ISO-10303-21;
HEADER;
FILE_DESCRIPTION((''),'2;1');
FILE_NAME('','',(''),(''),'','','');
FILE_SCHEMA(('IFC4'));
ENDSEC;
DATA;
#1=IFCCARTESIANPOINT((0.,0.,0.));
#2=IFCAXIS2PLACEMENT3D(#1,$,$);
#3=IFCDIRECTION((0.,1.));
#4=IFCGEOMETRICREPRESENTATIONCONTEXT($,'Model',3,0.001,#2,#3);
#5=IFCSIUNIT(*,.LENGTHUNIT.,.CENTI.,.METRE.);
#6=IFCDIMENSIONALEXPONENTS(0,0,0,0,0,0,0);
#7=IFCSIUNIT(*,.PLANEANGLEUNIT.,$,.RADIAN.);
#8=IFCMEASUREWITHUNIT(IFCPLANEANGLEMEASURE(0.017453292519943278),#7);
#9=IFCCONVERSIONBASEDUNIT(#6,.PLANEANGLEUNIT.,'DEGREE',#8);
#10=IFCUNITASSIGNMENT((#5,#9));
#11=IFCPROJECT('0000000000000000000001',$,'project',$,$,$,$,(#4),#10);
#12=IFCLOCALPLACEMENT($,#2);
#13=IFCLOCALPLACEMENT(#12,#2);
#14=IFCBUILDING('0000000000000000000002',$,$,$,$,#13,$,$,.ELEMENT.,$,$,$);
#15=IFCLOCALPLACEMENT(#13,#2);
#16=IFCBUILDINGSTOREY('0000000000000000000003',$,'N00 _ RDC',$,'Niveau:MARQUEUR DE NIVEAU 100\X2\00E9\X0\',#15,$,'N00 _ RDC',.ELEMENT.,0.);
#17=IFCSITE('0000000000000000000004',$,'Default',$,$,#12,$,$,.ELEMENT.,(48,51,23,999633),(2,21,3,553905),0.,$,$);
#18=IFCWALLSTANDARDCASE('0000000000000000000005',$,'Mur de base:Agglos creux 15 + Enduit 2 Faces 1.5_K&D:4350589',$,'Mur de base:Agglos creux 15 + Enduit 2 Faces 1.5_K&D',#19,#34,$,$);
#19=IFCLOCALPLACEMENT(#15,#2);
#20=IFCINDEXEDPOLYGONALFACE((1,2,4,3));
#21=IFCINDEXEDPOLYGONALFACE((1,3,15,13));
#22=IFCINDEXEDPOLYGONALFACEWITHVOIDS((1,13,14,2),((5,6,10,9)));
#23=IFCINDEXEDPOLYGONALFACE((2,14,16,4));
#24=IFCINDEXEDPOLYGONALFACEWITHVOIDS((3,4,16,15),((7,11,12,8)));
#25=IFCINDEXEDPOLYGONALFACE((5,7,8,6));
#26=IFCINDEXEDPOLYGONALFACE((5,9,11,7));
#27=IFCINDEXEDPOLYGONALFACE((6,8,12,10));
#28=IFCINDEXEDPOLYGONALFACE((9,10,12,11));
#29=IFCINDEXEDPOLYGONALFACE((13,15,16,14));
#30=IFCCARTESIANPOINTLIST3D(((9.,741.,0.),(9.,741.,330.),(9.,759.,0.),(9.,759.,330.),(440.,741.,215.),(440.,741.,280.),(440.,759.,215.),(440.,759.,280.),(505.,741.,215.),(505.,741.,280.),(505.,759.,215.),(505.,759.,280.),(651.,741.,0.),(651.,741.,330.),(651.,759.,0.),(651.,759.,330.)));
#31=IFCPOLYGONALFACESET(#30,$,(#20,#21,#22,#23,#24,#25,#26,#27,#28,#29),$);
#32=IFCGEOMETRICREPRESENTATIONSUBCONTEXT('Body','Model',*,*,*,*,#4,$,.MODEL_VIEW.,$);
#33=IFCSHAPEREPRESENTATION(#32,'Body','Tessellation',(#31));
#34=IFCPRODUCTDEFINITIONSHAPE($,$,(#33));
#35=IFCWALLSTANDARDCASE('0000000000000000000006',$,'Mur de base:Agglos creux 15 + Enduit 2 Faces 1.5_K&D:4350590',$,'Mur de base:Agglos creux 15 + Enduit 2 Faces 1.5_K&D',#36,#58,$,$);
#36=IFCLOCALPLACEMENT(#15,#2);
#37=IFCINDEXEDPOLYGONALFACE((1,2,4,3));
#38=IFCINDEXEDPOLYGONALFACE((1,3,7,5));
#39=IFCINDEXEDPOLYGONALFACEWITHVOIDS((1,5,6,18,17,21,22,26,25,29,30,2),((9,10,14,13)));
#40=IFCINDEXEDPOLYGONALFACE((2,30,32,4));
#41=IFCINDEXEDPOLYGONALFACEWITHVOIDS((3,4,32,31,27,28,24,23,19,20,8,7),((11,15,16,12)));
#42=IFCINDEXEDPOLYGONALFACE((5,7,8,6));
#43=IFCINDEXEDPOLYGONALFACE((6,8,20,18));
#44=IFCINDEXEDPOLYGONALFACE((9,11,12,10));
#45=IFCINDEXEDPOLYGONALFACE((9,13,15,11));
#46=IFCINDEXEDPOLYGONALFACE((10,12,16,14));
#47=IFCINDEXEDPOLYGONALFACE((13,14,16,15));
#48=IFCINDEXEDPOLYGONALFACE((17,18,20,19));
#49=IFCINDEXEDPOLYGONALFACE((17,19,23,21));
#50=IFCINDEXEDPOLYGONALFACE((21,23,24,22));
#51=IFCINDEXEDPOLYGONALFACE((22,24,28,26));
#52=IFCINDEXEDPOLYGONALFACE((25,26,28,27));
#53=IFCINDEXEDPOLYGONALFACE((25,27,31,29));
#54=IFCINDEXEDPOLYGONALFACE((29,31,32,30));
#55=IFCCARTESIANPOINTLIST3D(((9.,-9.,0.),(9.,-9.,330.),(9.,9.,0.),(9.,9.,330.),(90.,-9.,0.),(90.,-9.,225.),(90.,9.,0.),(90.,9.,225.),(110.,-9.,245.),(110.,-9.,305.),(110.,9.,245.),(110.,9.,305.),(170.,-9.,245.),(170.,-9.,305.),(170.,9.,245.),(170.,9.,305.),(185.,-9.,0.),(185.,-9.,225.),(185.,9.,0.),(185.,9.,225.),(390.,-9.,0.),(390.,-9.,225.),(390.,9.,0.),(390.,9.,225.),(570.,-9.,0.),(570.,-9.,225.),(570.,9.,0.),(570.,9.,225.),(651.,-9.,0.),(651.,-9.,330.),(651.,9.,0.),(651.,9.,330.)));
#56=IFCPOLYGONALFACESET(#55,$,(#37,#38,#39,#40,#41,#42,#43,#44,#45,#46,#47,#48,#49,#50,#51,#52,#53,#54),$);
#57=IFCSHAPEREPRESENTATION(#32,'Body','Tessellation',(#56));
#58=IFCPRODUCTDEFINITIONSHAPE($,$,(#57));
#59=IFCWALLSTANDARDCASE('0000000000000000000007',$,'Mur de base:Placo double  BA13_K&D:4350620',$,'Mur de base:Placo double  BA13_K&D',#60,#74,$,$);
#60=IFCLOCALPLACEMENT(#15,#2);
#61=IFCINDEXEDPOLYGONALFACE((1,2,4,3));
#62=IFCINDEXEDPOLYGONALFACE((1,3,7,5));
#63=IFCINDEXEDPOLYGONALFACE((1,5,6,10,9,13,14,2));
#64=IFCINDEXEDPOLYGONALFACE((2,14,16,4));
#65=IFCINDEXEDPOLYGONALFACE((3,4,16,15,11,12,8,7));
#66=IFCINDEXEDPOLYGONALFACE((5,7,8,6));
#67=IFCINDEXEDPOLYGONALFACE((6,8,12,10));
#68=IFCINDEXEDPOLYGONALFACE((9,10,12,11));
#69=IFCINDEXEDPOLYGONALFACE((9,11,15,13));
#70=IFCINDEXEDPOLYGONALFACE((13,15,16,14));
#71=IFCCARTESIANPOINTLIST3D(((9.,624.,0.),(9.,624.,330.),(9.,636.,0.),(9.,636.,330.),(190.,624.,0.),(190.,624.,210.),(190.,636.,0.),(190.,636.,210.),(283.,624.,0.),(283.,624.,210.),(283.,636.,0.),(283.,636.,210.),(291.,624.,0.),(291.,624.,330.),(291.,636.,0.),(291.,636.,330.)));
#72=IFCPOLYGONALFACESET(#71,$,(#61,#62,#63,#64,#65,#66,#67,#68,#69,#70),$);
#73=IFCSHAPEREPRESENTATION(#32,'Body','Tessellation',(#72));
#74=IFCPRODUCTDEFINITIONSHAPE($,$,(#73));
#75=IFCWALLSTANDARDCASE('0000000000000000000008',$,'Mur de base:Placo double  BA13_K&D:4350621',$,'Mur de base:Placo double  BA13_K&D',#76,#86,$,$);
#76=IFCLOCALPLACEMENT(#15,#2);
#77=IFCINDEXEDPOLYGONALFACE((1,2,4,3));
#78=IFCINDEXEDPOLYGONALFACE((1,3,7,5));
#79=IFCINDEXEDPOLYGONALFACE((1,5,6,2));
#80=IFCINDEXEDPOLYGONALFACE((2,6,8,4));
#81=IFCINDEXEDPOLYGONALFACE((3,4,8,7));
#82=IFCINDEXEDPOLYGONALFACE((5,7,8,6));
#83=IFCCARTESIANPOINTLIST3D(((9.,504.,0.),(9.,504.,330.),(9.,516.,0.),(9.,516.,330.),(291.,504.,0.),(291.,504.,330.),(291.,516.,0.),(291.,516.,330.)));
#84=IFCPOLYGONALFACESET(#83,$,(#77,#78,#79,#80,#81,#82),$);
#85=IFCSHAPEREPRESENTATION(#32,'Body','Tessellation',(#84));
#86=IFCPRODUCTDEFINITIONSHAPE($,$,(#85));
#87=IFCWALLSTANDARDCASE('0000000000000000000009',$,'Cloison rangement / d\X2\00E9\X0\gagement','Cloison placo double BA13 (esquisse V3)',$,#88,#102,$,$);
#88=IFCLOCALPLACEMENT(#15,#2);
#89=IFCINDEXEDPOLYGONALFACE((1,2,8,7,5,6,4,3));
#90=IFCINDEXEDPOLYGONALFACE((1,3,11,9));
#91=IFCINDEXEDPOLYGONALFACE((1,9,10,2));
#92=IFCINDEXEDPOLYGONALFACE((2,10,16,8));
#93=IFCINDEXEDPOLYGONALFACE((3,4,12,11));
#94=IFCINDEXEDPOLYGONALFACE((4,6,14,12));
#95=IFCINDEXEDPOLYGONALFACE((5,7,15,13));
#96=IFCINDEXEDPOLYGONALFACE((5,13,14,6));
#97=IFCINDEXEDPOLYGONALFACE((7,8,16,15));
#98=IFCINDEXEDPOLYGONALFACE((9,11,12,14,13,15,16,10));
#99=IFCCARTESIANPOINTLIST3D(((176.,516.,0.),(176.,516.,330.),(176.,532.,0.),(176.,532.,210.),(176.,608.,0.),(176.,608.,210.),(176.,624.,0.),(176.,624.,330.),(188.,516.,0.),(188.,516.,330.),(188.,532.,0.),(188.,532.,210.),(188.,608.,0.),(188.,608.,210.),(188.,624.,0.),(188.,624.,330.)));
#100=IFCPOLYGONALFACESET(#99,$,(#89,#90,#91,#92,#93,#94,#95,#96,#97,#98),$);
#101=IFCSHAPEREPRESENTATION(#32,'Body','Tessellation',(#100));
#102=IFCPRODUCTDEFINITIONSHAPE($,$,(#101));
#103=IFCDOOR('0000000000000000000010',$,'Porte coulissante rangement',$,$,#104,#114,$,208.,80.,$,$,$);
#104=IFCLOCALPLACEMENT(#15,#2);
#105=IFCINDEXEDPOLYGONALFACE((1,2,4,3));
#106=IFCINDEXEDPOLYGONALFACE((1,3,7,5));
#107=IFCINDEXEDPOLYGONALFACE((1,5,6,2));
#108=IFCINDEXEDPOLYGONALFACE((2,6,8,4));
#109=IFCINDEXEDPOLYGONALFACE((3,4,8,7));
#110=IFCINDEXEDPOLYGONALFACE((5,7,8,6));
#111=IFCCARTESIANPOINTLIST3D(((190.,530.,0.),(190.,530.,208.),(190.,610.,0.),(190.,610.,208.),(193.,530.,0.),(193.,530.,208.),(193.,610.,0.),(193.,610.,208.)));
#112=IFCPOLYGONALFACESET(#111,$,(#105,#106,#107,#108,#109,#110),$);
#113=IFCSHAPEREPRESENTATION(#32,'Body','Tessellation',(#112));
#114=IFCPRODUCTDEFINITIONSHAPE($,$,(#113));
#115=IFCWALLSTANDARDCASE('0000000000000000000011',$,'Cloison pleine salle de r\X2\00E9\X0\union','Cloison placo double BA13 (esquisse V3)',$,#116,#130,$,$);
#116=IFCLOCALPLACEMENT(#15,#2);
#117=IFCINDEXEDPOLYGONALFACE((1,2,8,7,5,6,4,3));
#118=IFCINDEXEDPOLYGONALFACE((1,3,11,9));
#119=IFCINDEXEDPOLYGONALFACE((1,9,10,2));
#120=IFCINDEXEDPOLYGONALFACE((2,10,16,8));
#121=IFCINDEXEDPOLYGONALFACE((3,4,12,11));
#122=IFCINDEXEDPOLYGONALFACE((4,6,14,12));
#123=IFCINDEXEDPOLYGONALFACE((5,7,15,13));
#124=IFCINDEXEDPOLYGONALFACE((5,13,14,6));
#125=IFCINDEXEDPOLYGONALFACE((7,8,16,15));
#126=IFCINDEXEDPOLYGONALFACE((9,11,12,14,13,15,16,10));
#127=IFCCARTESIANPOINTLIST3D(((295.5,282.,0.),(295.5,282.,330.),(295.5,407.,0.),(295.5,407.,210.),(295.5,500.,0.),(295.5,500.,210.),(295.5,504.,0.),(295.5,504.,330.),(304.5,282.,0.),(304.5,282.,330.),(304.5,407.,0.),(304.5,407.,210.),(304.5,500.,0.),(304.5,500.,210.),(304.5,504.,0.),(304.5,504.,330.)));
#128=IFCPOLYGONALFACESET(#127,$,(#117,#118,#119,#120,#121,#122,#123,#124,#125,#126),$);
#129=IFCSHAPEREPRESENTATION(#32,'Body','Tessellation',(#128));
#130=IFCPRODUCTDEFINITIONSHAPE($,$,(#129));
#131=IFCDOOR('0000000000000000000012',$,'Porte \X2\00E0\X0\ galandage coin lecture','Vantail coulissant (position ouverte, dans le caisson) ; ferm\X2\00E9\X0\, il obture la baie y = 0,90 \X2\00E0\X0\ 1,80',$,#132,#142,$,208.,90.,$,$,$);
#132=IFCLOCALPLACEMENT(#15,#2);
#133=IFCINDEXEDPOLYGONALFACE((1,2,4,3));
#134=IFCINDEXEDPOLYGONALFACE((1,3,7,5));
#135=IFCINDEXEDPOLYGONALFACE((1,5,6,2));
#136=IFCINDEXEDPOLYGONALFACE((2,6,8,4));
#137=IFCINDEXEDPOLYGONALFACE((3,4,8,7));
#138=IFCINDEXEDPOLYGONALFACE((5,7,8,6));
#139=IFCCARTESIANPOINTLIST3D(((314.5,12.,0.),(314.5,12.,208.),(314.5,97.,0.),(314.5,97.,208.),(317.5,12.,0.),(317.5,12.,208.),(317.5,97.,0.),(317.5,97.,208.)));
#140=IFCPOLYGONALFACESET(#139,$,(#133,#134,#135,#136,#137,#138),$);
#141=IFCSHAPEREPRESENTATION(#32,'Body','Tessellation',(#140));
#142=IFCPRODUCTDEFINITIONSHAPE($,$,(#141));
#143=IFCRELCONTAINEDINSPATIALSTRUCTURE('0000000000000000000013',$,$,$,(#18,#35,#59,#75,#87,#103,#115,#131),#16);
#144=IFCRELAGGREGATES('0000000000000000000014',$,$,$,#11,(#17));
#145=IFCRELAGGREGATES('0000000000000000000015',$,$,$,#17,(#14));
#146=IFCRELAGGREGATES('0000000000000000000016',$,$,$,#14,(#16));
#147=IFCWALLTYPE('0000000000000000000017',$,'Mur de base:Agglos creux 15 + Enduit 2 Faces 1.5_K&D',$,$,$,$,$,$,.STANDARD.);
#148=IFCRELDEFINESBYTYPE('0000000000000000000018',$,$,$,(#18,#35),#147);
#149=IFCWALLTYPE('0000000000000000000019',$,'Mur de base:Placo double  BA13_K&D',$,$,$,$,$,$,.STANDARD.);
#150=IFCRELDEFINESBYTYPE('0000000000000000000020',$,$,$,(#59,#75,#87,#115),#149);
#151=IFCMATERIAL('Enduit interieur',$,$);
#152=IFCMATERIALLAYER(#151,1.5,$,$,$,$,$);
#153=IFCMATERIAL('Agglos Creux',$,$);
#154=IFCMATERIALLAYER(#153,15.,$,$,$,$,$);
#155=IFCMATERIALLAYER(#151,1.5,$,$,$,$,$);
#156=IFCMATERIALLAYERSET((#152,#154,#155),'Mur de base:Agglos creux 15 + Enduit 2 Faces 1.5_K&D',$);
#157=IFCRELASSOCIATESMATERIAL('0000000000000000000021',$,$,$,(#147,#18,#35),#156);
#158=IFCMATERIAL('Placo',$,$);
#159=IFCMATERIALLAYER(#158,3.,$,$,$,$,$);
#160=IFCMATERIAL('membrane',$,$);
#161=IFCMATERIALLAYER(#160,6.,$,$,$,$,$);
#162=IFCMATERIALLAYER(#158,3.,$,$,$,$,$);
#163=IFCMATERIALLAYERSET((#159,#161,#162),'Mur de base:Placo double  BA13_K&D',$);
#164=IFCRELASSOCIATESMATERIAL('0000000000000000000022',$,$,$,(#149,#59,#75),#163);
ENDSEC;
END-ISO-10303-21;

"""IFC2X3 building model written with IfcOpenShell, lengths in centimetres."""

from ifc_helpers import new_model, entity, si_unit, converted_unit, direction, frame, frame_2d, origin, origin_with_axes, origin_2d_with_axis, place, context, subcontext, project, spatial, rectangle, extrude, material, layer, layer_set, layer_usage, type_object, element, fill, save


model = new_model("IFC2X3")

# Units and contexts
model_context = context("Model", 3, precision=0.001, world=origin(), true_north=direction((0.0, 1.0)))
body_context = subcontext(model_context, "Body", "Model", "MODEL_VIEW")
ifc_project = project(units=[si_unit("LENGTHUNIT", "METRE", prefix="CENTI"), converted_unit("PLANEANGLEUNIT", "DEGREE", entity("IfcPlaneAngleMeasure", 0.017453292519943278), si_unit("PLANEANGLEUNIT", "RADIAN"), dimensions=[0, 0, 0, 0, 0, 0, 0])], contexts=[model_context])

# Site, building, storey
site_placement = place(None, origin())
site = spatial("IfcSite", under=ifc_project, at=site_placement, Name="Default", CompositionType="ELEMENT", RefLatitude=(48, 51, 23, 999633), RefLongitude=(2, 21, 3, 553905), RefElevation=0.0)
building_placement = place(site_placement, origin())
building = spatial("IfcBuilding", under=site, at=building_placement, CompositionType="ELEMENT")
storey_placement = place(building_placement, origin())
storey = spatial("IfcBuildingStorey", under=building, at=storey_placement, Name="N00 _ RDC", ObjectType="Niveau:MARQUEUR DE NIVEAU 100é", LongName="N00 _ RDC", CompositionType="ELEMENT", Elevation=0.0)

# Wall, opening
ifc_material_1 = material(Name="Enduit interieur")
ifc_layer_1 = layer(ifc_material_1, 1.5)
ifc_material_2 = material(Name="Agglos Creux")
ifc_layer_2 = layer(ifc_material_2, 15.0)
ifc_layer_3 = layer(ifc_material_1, 1.5)
ifc_layer_set_1 = layer_set([ifc_layer_1, ifc_layer_2, ifc_layer_3], Name="Mur de base:Agglos creux 15 + Enduit 2 Faces 1.5_K&D")
ifc_layer_usage_1 = layer_usage(ifc_layer_set_1, "AXIS2", "NEGATIVE", 9.0)
wall_type_1 = type_object("IfcWallType", Name="Mur de base:Agglos creux 15 + Enduit 2 Faces 1.5_K&D", PredefinedType="STANDARD", material=ifc_layer_set_1)
wall_1_placement = place(storey_placement, frame((9.0, 750.0, 0.0)))
wall_1 = element("IfcWallStandardCase", 1, at=wall_1_placement, inside=storey, type_object=wall_type_1, material=ifc_layer_usage_1, Name="Mur de base:Agglos creux 15 + Enduit 2 Faces 1.5_K&D:4350589", ObjectType="Mur de base:Agglos creux 15 + Enduit 2 Faces 1.5_K&D", context=body_context, shape_type="SweptSolid", body=[
    extrude(rectangle(XDim=642.0, YDim=18.0, at=frame_2d((321.0, 0.0), x_axis=(-1.0, 0.0))), origin(), (0.0, 0.0, 1.0), 330.0),
])
opening_1_placement = place(wall_1_placement, origin())
element("IfcOpeningElement", 2, at=opening_1_placement, cuts=wall_1, ObjectType="Opening", context=body_context, shape_type="SweptSolid", body=[
    extrude(rectangle(XDim=65.0, YDim=65.0, at=frame_2d((0.0, 0.0), x_axis=(1.0, 0.0))), frame((463.5, -9.0, 247.5), z_axis=(0.0, 1.0, 0.0), x_axis=(0.0, 0.0, -1.0)), (0.0, 0.0, 1.0), 18.0),
])

# Wall, openings
ifc_layer_usage_2 = layer_usage(ifc_layer_set_1, "AXIS2", "NEGATIVE", 9.0)
wall_2_placement = place(storey_placement, frame((9.0, 0.0, 0.0)))
wall_2 = element("IfcWallStandardCase", 3, at=wall_2_placement, inside=storey, type_object=wall_type_1, material=ifc_layer_usage_2, Name="Mur de base:Agglos creux 15 + Enduit 2 Faces 1.5_K&D:4350590", ObjectType="Mur de base:Agglos creux 15 + Enduit 2 Faces 1.5_K&D", context=body_context, shape_type="SweptSolid", body=[
    extrude(rectangle(XDim=642.0, YDim=18.0, at=frame_2d((321.0, 0.0), x_axis=(1.0, 0.0))), origin(), (0.0, 0.0, 1.0), 330.0),
])
opening_2_placement = place(wall_2_placement, origin())
element("IfcOpeningElement", 4, at=opening_2_placement, cuts=wall_2, ObjectType="Opening", context=body_context, shape_type="SweptSolid", body=[
    extrude(rectangle(XDim=225.0, YDim=95.0, at=origin_2d_with_axis()), frame((128.5, -9.0, 112.5), z_axis=(0.0, 1.0, 0.0), x_axis=(0.0, 0.0, -1.0)), (0.0, 0.0, 1.0), 18.0),
])
opening_3_placement = place(wall_2_placement, origin())
element("IfcOpeningElement", 5, at=opening_3_placement, cuts=wall_2, ObjectType="Opening", context=body_context, shape_type="SweptSolid", body=[
    extrude(rectangle(XDim=225.0, YDim=180.0, at=frame_2d((0.0, 0.0), x_axis=(1.0, 0.0))), frame((471.0, -9.0, 112.5), z_axis=(0.0, 1.0, 0.0), x_axis=(0.0, 0.0, -1.0)), (0.0, 0.0, 1.0), 18.0),
])
opening_4_placement = place(wall_2_placement, origin())
element("IfcOpeningElement", 6, at=opening_4_placement, cuts=wall_2, ObjectType="Opening", context=body_context, shape_type="SweptSolid", body=[
    extrude(rectangle(XDim=60.0, YDim=60.0, at=frame_2d((0.0, 0.0), x_axis=(1.0, 0.0))), frame((131.0, -9.0, 275.0), z_axis=(0.0, 1.0, 0.0), x_axis=(0.0, 0.0, -1.0)), (0.0, 0.0, 1.0), 18.0),
])

# Wall, opening
ifc_material_3 = material(Name="Placo")
ifc_layer_4 = layer(ifc_material_3, 3.0)
ifc_material_4 = material(Name="membrane")
ifc_layer_5 = layer(ifc_material_4, 6.0)
ifc_layer_6 = layer(ifc_material_3, 3.0)
ifc_layer_set_2 = layer_set([ifc_layer_4, ifc_layer_5, ifc_layer_6], Name="Mur de base:Placo double  BA13_K&D")
ifc_layer_usage_3 = layer_usage(ifc_layer_set_2, "AXIS2", "NEGATIVE", 6.0)
wall_type_2 = type_object("IfcWallType", Name="Mur de base:Placo double  BA13_K&D", PredefinedType="STANDARD", material=ifc_layer_set_2)
wall_3_placement = place(storey_placement, frame((9.0, 630.0, 0.0)))
wall_3 = element("IfcWallStandardCase", 7, at=wall_3_placement, inside=storey, type_object=wall_type_2, material=ifc_layer_usage_3, Name="Mur de base:Placo double  BA13_K&D:4350620", ObjectType="Mur de base:Placo double  BA13_K&D", context=body_context, shape_type="SweptSolid", body=[
    extrude(rectangle(XDim=282.0, YDim=12.0, at=frame_2d((141.0, 0.0), x_axis=(-1.0, 0.0))), origin(), (0.0, 0.0, 1.0), 330.0),
])
opening_5_placement = place(wall_3_placement, frame((-9.0, -630.0, 0.0), z_axis=(0.0, 0.0, 1.0), x_axis=(1.0, 0.0, 0.0)))
element("IfcOpeningElement", 8, at=opening_5_placement, inside=storey, cuts=wall_3, context=body_context, shape_type="SweptSolid", body=[
    extrude(rectangle(XDim=93.0, YDim=16.0, at=frame_2d((236.5, 630.0))), origin(), (0.0, 0.0, 1.0), 210.0),
])

# Wall
ifc_layer_usage_4 = layer_usage(ifc_layer_set_2, "AXIS2", "POSITIVE", -6.0)
wall_4_placement = place(storey_placement, frame((9.0, 510.0, 0.0)))
element("IfcWallStandardCase", 9, at=wall_4_placement, inside=storey, type_object=wall_type_2, material=ifc_layer_usage_4, Name="Mur de base:Placo double  BA13_K&D:4350621", ObjectType="Mur de base:Placo double  BA13_K&D", context=body_context, shape_type="SweptSolid", body=[
    extrude(rectangle(XDim=282.0, YDim=12.0, at=frame_2d((141.0, 0.0), x_axis=(-1.0, 0.0))), origin(), (0.0, 0.0, 1.0), 330.0),
])

# Wall, opening, door
wall_5_placement = place(storey_placement, origin_with_axes())
wall_5 = element("IfcWallStandardCase", 10, at=wall_5_placement, inside=storey, type_object=wall_type_2, Name="Cloison rangement / dégagement", Description="Cloison placo double BA13 (esquisse V3)", context=body_context, shape_type="SweptSolid", body=[
    extrude(rectangle(XDim=12.0, YDim=108.0, at=frame_2d((182.0, 570.0))), origin(), (0.0, 0.0, 1.0), 330.0),
])
opening_6_placement = place(wall_5_placement, origin_with_axes())
opening_6 = element("IfcOpeningElement", 11, at=opening_6_placement, inside=storey, cuts=wall_5, context=body_context, shape_type="SweptSolid", body=[
    extrude(rectangle(XDim=16.0, YDim=76.0, at=frame_2d((182.0, 570.0))), origin(), (0.0, 0.0, 1.0), 210.0),
])
door_1_placement = place(storey_placement, origin_with_axes())
door_1 = element("IfcDoor", 12, at=door_1_placement, inside=storey, Name="Porte coulissante rangement", OverallHeight=208.0, OverallWidth=80.0, context=body_context, shape_type="SweptSolid", body=[
    extrude(rectangle(XDim=3.0, YDim=80.0, at=frame_2d((191.5, 570.0))), origin(), (0.0, 0.0, 1.0), 208.0),
])
fill(opening_6, door_1)

# Wall, opening
wall_6_placement = place(storey_placement, origin_with_axes())
wall_6 = element("IfcWallStandardCase", 13, at=wall_6_placement, inside=storey, type_object=wall_type_2, Name="Cloison pleine salle de réunion", Description="Cloison placo double BA13 (esquisse V3)", context=body_context, shape_type="SweptSolid", body=[
    extrude(rectangle(XDim=9.0, YDim=222.0, at=frame_2d((300.0, 393.0))), origin(), (0.0, 0.0, 1.0), 330.0),
])
opening_7_placement = place(wall_6_placement, origin_with_axes())
element("IfcOpeningElement", 14, at=opening_7_placement, inside=storey, cuts=wall_6, context=body_context, shape_type="SweptSolid", body=[
    extrude(rectangle(XDim=12.0, YDim=93.0, at=frame_2d((300.0, 453.5))), origin(), (0.0, 0.0, 1.0), 210.0),
])

# Door
door_2_placement = place(storey_placement, origin_with_axes())
element("IfcDoor", 15, at=door_2_placement, inside=storey, Name="Porte à galandage coin lecture", Description="Vantail coulissant (position ouverte, dans le caisson) ; fermé, il obture la baie y = 0,90 à 1,80", OverallHeight=208.0, OverallWidth=90.0, context=body_context, shape_type="SweptSolid", body=[
    extrude(rectangle(XDim=3.0, YDim=85.0, at=frame_2d((316.0, 54.5))), origin(), (0.0, 0.0, 1.0), 208.0),
])

save(model, "model.ifc")
